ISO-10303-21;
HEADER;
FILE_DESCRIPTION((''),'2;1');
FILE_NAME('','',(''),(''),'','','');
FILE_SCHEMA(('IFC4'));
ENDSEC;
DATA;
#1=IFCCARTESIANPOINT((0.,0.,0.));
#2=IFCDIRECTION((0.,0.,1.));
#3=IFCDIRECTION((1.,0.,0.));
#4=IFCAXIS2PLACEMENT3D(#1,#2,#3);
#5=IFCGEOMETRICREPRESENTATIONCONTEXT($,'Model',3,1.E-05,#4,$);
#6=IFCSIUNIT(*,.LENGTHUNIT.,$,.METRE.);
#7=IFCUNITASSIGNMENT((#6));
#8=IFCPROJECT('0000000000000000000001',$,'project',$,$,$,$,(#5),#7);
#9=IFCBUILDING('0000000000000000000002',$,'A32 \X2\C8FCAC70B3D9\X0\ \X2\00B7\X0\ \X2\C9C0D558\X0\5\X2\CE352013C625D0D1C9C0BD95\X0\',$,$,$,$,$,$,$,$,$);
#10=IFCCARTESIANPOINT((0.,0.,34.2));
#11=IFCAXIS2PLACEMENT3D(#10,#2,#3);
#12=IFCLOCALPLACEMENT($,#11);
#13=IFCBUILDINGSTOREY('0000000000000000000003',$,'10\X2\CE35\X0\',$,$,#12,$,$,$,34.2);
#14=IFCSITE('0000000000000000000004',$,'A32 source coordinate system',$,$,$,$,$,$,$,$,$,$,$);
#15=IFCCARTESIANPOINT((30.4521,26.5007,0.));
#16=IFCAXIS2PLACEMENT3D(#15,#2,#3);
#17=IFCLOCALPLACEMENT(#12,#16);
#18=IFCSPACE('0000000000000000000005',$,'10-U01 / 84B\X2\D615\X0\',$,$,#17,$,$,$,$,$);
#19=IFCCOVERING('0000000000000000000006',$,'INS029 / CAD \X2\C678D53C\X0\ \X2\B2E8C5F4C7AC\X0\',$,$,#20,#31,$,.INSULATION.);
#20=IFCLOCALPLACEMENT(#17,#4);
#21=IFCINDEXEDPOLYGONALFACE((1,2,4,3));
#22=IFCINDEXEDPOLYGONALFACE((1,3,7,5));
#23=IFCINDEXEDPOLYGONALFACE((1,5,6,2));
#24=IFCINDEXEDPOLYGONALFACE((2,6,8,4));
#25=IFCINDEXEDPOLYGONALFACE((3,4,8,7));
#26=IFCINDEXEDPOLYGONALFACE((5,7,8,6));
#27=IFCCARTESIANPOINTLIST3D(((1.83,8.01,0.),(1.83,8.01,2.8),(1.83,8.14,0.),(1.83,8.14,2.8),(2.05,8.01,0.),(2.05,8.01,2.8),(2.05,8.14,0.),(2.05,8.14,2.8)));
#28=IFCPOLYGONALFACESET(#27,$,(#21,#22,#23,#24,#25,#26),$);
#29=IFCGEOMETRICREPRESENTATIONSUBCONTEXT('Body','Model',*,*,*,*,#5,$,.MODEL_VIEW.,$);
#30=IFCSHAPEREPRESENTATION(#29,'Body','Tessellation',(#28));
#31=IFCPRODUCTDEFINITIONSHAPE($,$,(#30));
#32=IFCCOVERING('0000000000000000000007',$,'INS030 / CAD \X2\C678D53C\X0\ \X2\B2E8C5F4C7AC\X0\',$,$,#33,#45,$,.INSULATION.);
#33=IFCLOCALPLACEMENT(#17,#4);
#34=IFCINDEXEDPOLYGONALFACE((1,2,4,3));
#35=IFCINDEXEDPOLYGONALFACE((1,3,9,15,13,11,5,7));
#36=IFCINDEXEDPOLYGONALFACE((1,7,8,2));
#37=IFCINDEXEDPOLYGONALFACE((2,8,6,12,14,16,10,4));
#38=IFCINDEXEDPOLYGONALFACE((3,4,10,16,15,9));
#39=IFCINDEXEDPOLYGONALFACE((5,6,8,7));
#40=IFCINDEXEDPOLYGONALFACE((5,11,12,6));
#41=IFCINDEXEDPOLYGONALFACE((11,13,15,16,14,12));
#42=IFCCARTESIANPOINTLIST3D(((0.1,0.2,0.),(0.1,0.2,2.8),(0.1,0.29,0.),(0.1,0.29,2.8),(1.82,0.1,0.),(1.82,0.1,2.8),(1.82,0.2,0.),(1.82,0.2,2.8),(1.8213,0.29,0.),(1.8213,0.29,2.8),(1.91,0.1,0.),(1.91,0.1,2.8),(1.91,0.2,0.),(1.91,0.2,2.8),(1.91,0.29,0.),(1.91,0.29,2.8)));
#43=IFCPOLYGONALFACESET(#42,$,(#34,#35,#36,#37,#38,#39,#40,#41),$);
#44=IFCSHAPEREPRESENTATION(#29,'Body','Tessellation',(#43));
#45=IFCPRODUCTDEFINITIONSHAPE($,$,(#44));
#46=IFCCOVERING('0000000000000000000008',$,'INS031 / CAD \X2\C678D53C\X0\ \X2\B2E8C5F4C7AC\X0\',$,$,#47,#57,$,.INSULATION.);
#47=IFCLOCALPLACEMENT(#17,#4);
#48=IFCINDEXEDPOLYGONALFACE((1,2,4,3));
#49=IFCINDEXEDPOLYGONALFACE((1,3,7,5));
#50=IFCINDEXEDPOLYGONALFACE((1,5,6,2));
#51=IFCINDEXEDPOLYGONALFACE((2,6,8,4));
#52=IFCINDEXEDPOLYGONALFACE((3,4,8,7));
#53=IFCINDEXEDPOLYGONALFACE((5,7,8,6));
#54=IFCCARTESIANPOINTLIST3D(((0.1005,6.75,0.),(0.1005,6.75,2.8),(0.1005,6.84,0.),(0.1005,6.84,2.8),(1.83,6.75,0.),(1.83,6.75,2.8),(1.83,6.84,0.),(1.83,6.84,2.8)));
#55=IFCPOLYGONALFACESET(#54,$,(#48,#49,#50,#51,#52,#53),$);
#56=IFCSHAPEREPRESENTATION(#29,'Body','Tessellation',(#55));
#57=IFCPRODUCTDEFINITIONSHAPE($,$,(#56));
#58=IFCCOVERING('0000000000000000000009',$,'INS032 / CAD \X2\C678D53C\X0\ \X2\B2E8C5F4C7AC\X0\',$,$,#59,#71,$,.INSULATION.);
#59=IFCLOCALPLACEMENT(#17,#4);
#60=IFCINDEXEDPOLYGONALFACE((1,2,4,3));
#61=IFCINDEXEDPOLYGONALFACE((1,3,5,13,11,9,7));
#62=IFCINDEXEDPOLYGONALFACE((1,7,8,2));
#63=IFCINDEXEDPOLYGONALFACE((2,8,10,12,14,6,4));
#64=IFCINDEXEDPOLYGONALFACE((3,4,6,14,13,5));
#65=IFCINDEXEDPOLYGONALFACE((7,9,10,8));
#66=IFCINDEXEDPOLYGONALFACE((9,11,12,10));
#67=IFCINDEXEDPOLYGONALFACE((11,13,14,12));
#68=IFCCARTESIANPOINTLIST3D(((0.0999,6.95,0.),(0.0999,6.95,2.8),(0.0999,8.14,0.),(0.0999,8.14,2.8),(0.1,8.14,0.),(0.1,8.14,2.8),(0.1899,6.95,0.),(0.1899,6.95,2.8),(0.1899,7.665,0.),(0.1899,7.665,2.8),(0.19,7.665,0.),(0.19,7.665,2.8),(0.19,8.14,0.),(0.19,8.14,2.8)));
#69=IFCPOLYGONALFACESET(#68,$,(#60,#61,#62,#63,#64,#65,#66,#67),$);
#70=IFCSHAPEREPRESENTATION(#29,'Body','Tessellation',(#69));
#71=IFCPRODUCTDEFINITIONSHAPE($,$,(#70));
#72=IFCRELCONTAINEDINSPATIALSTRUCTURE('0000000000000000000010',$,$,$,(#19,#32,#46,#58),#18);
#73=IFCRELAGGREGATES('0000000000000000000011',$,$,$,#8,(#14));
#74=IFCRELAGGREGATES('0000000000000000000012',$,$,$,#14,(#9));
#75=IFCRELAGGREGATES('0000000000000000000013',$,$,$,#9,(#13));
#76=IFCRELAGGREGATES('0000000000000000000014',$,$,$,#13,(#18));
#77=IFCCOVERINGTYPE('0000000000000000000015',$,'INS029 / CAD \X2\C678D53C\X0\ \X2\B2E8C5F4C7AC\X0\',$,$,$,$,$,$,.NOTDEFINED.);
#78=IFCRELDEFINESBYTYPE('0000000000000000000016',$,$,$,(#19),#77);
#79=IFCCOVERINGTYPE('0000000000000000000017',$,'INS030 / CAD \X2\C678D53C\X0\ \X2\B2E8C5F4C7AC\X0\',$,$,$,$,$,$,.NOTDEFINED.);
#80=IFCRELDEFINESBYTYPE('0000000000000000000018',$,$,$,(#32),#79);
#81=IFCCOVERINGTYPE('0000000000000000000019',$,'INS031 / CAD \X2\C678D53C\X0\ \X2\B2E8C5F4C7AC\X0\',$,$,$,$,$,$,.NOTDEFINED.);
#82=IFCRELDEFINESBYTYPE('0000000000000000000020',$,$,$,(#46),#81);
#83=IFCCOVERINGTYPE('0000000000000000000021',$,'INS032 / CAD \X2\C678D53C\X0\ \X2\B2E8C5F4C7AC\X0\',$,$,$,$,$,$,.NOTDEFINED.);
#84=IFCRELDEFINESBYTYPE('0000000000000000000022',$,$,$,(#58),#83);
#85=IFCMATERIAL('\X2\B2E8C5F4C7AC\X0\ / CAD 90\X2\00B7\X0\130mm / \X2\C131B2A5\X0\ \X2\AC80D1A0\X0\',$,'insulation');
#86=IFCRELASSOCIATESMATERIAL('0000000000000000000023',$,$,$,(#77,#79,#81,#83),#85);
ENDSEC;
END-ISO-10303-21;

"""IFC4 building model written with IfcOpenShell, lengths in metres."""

from ifc_helpers import new_model, si_unit, frame, origin, origin_with_axes, place, context, subcontext, project, spatial, polyline, outline, extrude, source, transform, mapped, material, type_object, type_shapes, element, save


model = new_model("IFC4")

# Units and contexts
model_context = context("Model", 3, precision=1e-05, world=origin_with_axes())
body_context = subcontext(model_context, "Body", "Model", "MODEL_VIEW")
ifc_project = project(units=[si_unit("LENGTHUNIT", "METRE")], contexts=[model_context])

# Site, building, storey, space
storey_placement = place(None, frame((0.0, 0.0, 34.2), z_axis=(0.0, 0.0, 1.0), x_axis=(1.0, 0.0, 0.0)))
space_placement = place(storey_placement, frame((30.4521, 26.5007, 0.0), z_axis=(0.0, 0.0, 1.0), x_axis=(1.0, 0.0, 0.0)))
site = spatial("IfcSite", under=ifc_project, Name="A32 source coordinate system")
building = spatial("IfcBuilding", under=site, Name="A32 주거동 · 지하5층–옥탑지붕")
storey = spatial("IfcBuildingStorey", under=building, at=storey_placement, Name="10층", Elevation=34.2)
space = spatial("IfcSpace", under=storey, at=space_placement, Name="10-U01 / 84B형")

# Coverings
ifc_material = material(Name="단열재 / CAD 90·130mm / 성능 검토", Category="insulation")
covering_type_1 = type_object("IfcCoveringType", Name="INS029 / CAD 외피 단열재", PredefinedType="NOTDEFINED", material=ifc_material)
shared_shape_1 = source(origin(), body_context, "Body", "SweptSolid", [
    extrude(outline(polyline([(1.83, 8.01), (1.83, 8.14), (2.05, 8.14), (2.05, 8.01), (1.83, 8.01)])), origin(), (0.0, 0.0, 1.0), 2.8),
])
type_shapes(covering_type_1, [shared_shape_1])
covering_1_placement = place(space_placement, origin_with_axes())
element("IfcCovering", 1, at=covering_1_placement, inside=space, type_object=covering_type_1, Name="INS029 / CAD 외피 단열재", PredefinedType="INSULATION", context=body_context, shape_type="MappedRepresentation", body=[
    mapped(shared_shape_1, transform((0.0, 0.0, 0.0), scale=1.0)),
])
covering_type_2 = type_object("IfcCoveringType", Name="INS030 / CAD 외피 단열재", PredefinedType="NOTDEFINED", material=ifc_material)
shared_shape_2 = source(origin(), body_context, "Body", "SweptSolid", [
    extrude(outline(polyline([(1.91, 0.2), (1.91, 0.1), (1.82, 0.1), (1.82, 0.2), (0.1, 0.2), (0.1, 0.29), (1.8213, 0.29), (1.91, 0.29), (1.91, 0.2)])), origin(), (0.0, 0.0, 1.0), 2.8),
])
type_shapes(covering_type_2, [shared_shape_2])
covering_2_placement = place(space_placement, origin_with_axes())
element("IfcCovering", 2, at=covering_2_placement, inside=space, type_object=covering_type_2, Name="INS030 / CAD 외피 단열재", PredefinedType="INSULATION", context=body_context, shape_type="MappedRepresentation", body=[
    mapped(shared_shape_2, transform((0.0, 0.0, 0.0), scale=1.0)),
])
covering_type_3 = type_object("IfcCoveringType", Name="INS031 / CAD 외피 단열재", PredefinedType="NOTDEFINED", material=ifc_material)
shared_shape_3 = source(origin(), body_context, "Body", "SweptSolid", [
    extrude(outline(polyline([(1.83, 6.75), (0.1005, 6.75), (0.1005, 6.84), (1.83, 6.84), (1.83, 6.75)])), origin(), (0.0, 0.0, 1.0), 2.8),
])
type_shapes(covering_type_3, [shared_shape_3])
covering_3_placement = place(space_placement, origin_with_axes())
element("IfcCovering", 3, at=covering_3_placement, inside=space, type_object=covering_type_3, Name="INS031 / CAD 외피 단열재", PredefinedType="INSULATION", context=body_context, shape_type="MappedRepresentation", body=[
    mapped(shared_shape_3, transform((0.0, 0.0, 0.0), scale=1.0)),
])
covering_type_4 = type_object("IfcCoveringType", Name="INS032 / CAD 외피 단열재", PredefinedType="NOTDEFINED", material=ifc_material)
shared_shape_4 = source(origin(), body_context, "Body", "SweptSolid", [
    extrude(outline(polyline([(0.1899, 6.95), (0.0999, 6.95), (0.0999, 8.14), (0.1, 8.14), (0.19, 8.14), (0.19, 7.665), (0.1899, 7.665), (0.1899, 6.95)])), origin(), (0.0, 0.0, 1.0), 2.8),
])
type_shapes(covering_type_4, [shared_shape_4])
covering_4_placement = place(space_placement, origin_with_axes())
element("IfcCovering", 4, at=covering_4_placement, inside=space, type_object=covering_type_4, Name="INS032 / CAD 외피 단열재", PredefinedType="INSULATION", context=body_context, shape_type="MappedRepresentation", body=[
    mapped(shared_shape_4, transform((0.0, 0.0, 0.0), scale=1.0)),
])

save(model, "model.ifc")
